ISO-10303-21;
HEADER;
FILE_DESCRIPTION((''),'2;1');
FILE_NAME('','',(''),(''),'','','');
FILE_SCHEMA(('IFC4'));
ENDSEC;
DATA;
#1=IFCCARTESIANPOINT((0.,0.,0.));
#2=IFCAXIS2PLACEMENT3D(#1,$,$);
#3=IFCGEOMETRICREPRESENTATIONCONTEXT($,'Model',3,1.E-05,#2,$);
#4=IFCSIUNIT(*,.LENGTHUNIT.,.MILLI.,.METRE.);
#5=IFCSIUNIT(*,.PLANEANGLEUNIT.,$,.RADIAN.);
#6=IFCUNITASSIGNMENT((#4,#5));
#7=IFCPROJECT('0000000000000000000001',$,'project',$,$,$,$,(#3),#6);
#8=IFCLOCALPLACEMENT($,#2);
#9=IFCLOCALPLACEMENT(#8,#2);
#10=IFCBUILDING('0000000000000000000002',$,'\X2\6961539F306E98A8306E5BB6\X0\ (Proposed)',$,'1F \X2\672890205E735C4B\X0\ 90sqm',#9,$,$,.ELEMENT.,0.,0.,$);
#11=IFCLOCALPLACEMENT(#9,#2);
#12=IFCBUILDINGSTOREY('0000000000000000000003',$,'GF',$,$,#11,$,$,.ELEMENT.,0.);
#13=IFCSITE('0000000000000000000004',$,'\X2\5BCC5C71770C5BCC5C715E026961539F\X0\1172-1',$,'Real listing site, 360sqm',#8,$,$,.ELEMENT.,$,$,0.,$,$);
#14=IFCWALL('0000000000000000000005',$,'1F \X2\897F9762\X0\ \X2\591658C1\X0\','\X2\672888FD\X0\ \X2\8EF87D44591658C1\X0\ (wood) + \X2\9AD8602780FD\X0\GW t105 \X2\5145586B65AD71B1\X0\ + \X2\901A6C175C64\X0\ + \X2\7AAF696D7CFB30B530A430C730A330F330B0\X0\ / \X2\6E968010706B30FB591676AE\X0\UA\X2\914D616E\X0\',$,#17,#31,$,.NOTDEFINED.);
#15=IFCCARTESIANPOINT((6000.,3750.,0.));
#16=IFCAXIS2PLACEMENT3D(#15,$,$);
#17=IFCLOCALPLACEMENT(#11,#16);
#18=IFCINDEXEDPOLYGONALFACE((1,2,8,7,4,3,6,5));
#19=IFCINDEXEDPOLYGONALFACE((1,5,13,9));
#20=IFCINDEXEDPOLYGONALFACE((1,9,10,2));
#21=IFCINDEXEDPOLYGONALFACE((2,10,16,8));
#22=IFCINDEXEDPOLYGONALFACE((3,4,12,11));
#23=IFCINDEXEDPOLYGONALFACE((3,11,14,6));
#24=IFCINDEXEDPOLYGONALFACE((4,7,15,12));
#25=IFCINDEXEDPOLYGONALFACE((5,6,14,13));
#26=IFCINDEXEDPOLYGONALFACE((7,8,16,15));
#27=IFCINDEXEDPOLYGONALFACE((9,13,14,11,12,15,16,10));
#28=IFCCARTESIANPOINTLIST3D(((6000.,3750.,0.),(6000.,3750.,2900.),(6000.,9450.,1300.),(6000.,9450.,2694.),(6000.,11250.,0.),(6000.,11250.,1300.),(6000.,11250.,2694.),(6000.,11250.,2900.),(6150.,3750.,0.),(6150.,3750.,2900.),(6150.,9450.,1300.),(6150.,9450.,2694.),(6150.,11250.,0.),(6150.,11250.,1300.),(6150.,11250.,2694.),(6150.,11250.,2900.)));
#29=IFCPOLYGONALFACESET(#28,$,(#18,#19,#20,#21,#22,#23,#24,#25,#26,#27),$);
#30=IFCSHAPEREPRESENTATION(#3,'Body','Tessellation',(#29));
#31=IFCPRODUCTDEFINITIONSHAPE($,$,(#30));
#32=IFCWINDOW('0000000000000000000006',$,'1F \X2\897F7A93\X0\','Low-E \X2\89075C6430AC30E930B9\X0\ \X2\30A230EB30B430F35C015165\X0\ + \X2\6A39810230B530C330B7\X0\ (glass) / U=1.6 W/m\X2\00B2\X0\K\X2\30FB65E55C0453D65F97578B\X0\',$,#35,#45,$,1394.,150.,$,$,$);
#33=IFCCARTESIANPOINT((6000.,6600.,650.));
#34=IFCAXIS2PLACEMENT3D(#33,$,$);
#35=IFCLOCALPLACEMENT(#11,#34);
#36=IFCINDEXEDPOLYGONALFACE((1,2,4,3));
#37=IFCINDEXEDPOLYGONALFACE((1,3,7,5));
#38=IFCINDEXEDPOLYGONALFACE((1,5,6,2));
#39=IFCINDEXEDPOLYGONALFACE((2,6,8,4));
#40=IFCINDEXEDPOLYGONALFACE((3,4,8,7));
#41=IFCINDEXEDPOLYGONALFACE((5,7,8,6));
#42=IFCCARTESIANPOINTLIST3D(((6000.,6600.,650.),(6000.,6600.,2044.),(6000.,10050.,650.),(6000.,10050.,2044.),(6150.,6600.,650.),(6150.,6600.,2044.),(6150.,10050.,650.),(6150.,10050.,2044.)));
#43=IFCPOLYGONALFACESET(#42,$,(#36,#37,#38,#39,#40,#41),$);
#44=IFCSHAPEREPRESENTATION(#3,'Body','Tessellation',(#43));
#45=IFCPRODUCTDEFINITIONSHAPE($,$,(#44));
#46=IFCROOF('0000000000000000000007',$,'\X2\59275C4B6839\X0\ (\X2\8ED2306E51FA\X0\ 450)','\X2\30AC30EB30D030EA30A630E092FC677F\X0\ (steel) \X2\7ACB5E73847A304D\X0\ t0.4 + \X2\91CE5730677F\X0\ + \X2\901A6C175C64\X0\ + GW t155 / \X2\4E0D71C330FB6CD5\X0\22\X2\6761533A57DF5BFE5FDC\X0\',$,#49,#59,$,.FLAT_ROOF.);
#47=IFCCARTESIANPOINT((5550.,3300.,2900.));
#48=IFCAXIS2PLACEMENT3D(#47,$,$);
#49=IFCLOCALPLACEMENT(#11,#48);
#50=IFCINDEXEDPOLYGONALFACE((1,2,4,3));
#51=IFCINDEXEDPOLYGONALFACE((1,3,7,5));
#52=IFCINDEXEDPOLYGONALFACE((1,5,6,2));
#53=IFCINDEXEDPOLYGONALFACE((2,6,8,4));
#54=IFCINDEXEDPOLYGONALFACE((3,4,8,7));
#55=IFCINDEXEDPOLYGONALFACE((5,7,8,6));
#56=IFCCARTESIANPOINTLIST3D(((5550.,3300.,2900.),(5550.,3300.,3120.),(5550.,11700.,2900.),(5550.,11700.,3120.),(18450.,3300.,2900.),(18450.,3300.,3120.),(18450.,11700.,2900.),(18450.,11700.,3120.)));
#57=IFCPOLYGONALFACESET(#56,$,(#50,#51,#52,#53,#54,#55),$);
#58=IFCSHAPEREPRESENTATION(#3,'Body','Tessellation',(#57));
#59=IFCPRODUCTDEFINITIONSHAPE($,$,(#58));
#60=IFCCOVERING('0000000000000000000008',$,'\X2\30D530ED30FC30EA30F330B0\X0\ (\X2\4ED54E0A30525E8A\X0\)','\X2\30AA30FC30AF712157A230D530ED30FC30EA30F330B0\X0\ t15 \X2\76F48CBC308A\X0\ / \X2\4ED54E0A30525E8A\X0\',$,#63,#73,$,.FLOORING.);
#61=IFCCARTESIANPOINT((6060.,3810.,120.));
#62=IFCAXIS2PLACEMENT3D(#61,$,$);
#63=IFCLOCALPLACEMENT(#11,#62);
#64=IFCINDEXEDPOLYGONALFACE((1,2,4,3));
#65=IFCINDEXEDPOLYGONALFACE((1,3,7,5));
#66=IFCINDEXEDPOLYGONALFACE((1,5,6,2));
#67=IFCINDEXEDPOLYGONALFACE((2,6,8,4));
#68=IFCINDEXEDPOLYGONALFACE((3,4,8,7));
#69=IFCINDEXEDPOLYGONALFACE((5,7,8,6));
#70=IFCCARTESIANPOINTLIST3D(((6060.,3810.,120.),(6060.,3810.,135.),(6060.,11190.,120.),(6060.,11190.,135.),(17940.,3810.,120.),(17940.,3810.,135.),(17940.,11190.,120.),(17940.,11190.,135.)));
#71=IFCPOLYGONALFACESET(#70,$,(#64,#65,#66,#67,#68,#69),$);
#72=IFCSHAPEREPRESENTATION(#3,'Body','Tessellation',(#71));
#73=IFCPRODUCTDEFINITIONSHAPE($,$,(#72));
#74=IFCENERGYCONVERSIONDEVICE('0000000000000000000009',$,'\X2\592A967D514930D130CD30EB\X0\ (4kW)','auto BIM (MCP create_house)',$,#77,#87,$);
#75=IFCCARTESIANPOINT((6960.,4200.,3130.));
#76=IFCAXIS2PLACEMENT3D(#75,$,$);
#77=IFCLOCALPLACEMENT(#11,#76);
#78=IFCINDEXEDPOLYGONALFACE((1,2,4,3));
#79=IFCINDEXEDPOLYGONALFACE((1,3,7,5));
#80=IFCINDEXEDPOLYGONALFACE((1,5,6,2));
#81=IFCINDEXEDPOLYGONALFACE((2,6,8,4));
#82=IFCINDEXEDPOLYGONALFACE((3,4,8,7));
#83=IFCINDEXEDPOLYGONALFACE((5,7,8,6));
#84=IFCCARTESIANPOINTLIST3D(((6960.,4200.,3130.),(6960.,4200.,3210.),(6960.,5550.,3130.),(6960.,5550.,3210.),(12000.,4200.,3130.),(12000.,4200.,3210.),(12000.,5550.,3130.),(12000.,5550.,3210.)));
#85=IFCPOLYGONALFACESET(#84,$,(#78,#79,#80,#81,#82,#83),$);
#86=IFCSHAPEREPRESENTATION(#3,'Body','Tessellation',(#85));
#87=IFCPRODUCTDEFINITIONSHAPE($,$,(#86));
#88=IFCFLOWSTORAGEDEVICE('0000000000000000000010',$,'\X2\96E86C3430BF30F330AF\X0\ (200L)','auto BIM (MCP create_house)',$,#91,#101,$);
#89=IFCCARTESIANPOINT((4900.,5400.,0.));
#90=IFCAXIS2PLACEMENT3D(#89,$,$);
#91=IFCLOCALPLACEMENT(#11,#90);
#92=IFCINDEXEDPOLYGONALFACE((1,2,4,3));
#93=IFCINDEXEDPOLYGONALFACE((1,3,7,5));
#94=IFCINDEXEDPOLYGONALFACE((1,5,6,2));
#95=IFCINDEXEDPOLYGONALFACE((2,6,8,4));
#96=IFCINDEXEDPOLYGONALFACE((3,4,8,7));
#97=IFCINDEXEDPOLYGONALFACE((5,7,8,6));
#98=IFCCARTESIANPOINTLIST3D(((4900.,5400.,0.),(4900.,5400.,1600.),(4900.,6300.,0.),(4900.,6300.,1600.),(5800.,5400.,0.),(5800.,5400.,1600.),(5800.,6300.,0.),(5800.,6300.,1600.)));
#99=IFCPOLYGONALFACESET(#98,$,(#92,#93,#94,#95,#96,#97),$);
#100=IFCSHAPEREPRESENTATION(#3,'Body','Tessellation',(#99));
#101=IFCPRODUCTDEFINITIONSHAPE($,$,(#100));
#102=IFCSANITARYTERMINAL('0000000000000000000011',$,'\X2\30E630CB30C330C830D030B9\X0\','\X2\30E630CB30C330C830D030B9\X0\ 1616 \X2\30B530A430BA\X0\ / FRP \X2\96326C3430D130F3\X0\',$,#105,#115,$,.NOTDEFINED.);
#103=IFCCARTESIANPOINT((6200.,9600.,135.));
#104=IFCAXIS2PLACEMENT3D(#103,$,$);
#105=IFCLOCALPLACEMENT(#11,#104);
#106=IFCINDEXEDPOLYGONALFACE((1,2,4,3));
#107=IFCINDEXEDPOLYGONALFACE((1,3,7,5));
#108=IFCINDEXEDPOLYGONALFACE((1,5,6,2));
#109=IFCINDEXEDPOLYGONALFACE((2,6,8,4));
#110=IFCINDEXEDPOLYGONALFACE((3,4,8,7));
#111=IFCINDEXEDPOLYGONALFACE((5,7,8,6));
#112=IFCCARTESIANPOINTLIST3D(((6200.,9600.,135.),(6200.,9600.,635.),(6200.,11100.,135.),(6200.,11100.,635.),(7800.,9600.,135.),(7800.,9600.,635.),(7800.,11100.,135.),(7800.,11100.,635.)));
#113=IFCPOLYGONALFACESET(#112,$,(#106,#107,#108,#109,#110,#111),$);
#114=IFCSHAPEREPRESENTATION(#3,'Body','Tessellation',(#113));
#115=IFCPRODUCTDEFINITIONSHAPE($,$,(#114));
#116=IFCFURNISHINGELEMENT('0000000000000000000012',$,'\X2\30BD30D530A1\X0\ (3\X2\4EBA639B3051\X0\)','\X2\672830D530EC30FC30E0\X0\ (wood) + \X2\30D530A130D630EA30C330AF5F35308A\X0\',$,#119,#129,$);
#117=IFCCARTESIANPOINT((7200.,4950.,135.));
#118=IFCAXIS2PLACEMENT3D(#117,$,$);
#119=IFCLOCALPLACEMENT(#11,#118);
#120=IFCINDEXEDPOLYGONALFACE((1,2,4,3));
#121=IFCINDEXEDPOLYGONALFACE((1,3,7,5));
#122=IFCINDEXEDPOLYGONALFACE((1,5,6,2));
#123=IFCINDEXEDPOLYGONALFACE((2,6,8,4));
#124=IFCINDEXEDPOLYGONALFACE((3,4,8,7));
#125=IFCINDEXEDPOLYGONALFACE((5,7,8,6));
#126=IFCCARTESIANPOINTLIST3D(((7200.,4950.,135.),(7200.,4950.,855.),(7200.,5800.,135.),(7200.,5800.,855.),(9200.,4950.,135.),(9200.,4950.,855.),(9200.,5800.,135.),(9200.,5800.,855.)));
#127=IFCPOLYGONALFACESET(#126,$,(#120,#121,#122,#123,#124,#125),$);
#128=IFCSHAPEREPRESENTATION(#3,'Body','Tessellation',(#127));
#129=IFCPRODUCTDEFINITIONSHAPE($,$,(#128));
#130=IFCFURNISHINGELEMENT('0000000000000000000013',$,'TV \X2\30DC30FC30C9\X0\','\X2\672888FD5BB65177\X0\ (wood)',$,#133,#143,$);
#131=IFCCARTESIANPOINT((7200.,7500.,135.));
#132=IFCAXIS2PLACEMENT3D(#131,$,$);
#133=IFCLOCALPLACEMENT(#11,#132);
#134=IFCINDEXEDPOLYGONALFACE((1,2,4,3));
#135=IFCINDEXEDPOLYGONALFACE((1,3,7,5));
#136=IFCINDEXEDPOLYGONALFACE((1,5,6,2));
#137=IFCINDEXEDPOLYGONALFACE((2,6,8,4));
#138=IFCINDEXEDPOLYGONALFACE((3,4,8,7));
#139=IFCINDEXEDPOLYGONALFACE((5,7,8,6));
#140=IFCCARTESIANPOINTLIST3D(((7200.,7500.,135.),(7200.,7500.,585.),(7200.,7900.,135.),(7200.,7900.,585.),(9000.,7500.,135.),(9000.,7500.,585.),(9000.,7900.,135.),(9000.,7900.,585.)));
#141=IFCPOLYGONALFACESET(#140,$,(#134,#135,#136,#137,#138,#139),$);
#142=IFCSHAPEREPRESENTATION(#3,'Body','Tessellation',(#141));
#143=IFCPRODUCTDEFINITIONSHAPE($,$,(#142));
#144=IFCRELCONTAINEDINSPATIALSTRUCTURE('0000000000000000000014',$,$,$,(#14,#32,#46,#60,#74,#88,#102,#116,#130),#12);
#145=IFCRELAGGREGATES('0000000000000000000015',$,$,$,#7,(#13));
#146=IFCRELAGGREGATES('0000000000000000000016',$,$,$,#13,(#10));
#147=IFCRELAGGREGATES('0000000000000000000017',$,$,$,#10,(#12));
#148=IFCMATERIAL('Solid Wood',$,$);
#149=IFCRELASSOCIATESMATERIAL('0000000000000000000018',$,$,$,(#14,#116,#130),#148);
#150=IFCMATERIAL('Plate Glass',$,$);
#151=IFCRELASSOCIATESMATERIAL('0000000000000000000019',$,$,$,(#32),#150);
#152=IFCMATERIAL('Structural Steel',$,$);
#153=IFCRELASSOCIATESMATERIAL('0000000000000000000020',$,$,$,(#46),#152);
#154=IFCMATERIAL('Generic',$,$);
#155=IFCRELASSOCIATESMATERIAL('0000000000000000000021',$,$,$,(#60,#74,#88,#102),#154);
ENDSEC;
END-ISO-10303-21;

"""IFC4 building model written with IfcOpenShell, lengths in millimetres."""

from ifc_helpers import new_model, si_unit, frame, frame_2d, origin, place, context, project, spatial, rectangle, extrude, material, element, fill, save


model = new_model("IFC4")

# Units and contexts
model_context = context("Model", 3, precision=1e-05, world=origin())
ifc_project = project(units=[si_unit("LENGTHUNIT", "METRE", prefix="MILLI"), si_unit("PLANEANGLEUNIT", "RADIAN")], contexts=[model_context])

# Site, building, storey
site_placement = place(None, origin())
site = spatial("IfcSite", under=ifc_project, at=site_placement, Name="富山県富山市楡原1172-1", ObjectType="Real listing site, 360sqm", CompositionType="ELEMENT", RefElevation=0.0)
building_placement = place(site_placement, origin())
building = spatial("IfcBuilding", under=site, at=building_placement, Name="楡原の風の家 (Proposed)", ObjectType="1F 木造平屋 90sqm", CompositionType="ELEMENT", ElevationOfRefHeight=0.0, ElevationOfTerrain=0.0)
storey_placement = place(building_placement, origin())
storey = spatial("IfcBuildingStorey", under=building, at=storey_placement, Name="GF", CompositionType="ELEMENT", Elevation=0.0)

# Shared definitions
ifc_material_1 = material(Name="Solid Wood")

# Shared definitions
ifc_material_2 = material(Name="Plate Glass")

# Wall, opening, window
wall_1_placement = place(storey_placement, frame((6000.0, 3750.0, 0.0)))
wall_1 = element("IfcWall", 1, at=wall_1_placement, inside=storey, material=ifc_material_1, Name="1F 西面 外壁", Description="木製 軸組外壁 (wood) + 高性能GW t105 充填断熱 + 通気層 + 窯業系サイディング / 準耐火・外皮UA配慮", PredefinedType="NOTDEFINED", context=model_context, shape_type="SweptSolid", body=[
    extrude(rectangle(XDim=150.0, YDim=7500.0, at=frame_2d((75.0, 3750.0))), frame((6000.0, 3750.0, 0.0)), (0.0, 0.0, 1.0), 2900.0),
])
opening_1_placement = place(storey_placement, frame((6000.0, 6600.0, 650.0)))
opening_1 = element("IfcOpeningElement", 2, at=opening_1_placement, cuts=wall_1, PredefinedType="NOTDEFINED", context=model_context, shape_type="SweptSolid", body=[
    extrude(rectangle(XDim=150.0, YDim=3450.0, at=frame_2d((75.0, 1725.0))), frame((6000.0, 6600.0, 650.0)), (0.0, 0.0, 1.0), 1394.0),
])
window_1_placement = place(storey_placement, frame((6000.0, 6600.0, 650.0)))
window_1 = element("IfcWindow", 3, at=window_1_placement, inside=storey, material=ifc_material_2, Name="1F 西窓", Description="Low-E 複層ガラス アルゴン封入 + 樹脂サッシ (glass) / U=1.6 W/m²K・日射取得型", OverallHeight=1394.0, OverallWidth=150.0, context=model_context, shape_type="SweptSolid", body=[
    extrude(rectangle(XDim=150.0, YDim=3450.0, at=frame_2d((75.0, 1725.0))), frame((6000.0, 6600.0, 650.0)), (0.0, 0.0, 1.0), 1394.0),
])
fill(opening_1, window_1)

# Roof
ifc_material_3 = material(Name="Structural Steel")
roof_placement = place(storey_placement, frame((5550.0, 3300.0, 2900.0)))
element("IfcRoof", 4, at=roof_placement, inside=storey, material=ifc_material_3, Name="大屋根 (軒の出 450)", Description="ガルバリウム鋼板 (steel) 立平葺き t0.4 + 野地板 + 通気層 + GW t155 / 不燃・法22条区域対応", PredefinedType="FLAT_ROOF", context=model_context, shape_type="SweptSolid", body=[
    extrude(rectangle(XDim=12900.0, YDim=8400.0, at=frame_2d((6450.0, 4200.0))), frame((5550.0, 3300.0, 2900.0)), (0.0, 0.0, 1.0), 220.0),
])

# Covering
ifc_material_4 = material(Name="Generic")
covering_placement = place(storey_placement, frame((6060.0, 3810.0, 120.0)))
element("IfcCovering", 5, at=covering_placement, inside=storey, material=ifc_material_4, Name="フローリング (仕上げ床)", Description="オーク無垢フローリング t15 直貼り / 仕上げ床", PredefinedType="FLOORING", context=model_context, shape_type="SweptSolid", body=[
    extrude(rectangle(XDim=11880.0, YDim=7380.0, at=frame_2d((5940.0, 3690.0))), frame((6060.0, 3810.0, 120.0)), (0.0, 0.0, 1.0), 15.0),
])

# Energy conversion device
energy_conversion_device_placement = place(storey_placement, frame((6960.0, 4200.0, 3130.0)))
element("IfcEnergyConversionDevice", 6, at=energy_conversion_device_placement, inside=storey, material=ifc_material_4, Name="太陽光パネル (4kW)", Description="auto BIM (MCP create_house)", context=model_context, shape_type="SweptSolid", body=[
    extrude(rectangle(XDim=5040.0, YDim=1350.0, at=frame_2d((2520.0, 675.0))), frame((6960.0, 4200.0, 3130.0)), (0.0, 0.0, 1.0), 80.0),
])

# Flow storage device
flow_storage_device_placement = place(storey_placement, frame((4900.0, 5400.0, 0.0)))
element("IfcFlowStorageDevice", 7, at=flow_storage_device_placement, inside=storey, material=ifc_material_4, Name="雨水タンク (200L)", Description="auto BIM (MCP create_house)", context=model_context, shape_type="SweptSolid", body=[
    extrude(rectangle(XDim=900.0, YDim=900.0, at=frame_2d((450.0, 450.0))), frame((4900.0, 5400.0, 0.0)), (0.0, 0.0, 1.0), 1600.0),
])

# Sanitary terminal
sanitary_terminal_placement = place(storey_placement, frame((6200.0, 9600.0, 135.0)))
element("IfcSanitaryTerminal", 8, at=sanitary_terminal_placement, inside=storey, material=ifc_material_4, Name="ユニットバス", Description="ユニットバス 1616 サイズ / FRP 防水パン", PredefinedType="NOTDEFINED", context=model_context, shape_type="SweptSolid", body=[
    extrude(rectangle(XDim=1600.0, YDim=1500.0, at=frame_2d((800.0, 750.0))), frame((6200.0, 9600.0, 135.0)), (0.0, 0.0, 1.0), 500.0),
])

# Furnishing elements
furnishing_1_placement = place(storey_placement, frame((7200.0, 4950.0, 135.0)))
element("IfcFurnishingElement", 9, at=furnishing_1_placement, inside=storey, material=ifc_material_1, Name="ソファ (3人掛け)", Description="木フレーム (wood) + ファブリック張り", context=model_context, shape_type="SweptSolid", body=[
    extrude(rectangle(XDim=2000.0, YDim=850.0, at=frame_2d((1000.0, 425.0))), frame((7200.0, 4950.0, 135.0)), (0.0, 0.0, 1.0), 720.0),
])
furnishing_2_placement = place(storey_placement, frame((7200.0, 7500.0, 135.0)))
element("IfcFurnishingElement", 10, at=furnishing_2_placement, inside=storey, material=ifc_material_1, Name="TV ボード", Description="木製家具 (wood)", context=model_context, shape_type="SweptSolid", body=[
    extrude(rectangle(XDim=1800.0, YDim=400.0, at=frame_2d((900.0, 200.0))), frame((7200.0, 7500.0, 135.0)), (0.0, 0.0, 1.0), 450.0),
])

save(model, "model.ifc")
